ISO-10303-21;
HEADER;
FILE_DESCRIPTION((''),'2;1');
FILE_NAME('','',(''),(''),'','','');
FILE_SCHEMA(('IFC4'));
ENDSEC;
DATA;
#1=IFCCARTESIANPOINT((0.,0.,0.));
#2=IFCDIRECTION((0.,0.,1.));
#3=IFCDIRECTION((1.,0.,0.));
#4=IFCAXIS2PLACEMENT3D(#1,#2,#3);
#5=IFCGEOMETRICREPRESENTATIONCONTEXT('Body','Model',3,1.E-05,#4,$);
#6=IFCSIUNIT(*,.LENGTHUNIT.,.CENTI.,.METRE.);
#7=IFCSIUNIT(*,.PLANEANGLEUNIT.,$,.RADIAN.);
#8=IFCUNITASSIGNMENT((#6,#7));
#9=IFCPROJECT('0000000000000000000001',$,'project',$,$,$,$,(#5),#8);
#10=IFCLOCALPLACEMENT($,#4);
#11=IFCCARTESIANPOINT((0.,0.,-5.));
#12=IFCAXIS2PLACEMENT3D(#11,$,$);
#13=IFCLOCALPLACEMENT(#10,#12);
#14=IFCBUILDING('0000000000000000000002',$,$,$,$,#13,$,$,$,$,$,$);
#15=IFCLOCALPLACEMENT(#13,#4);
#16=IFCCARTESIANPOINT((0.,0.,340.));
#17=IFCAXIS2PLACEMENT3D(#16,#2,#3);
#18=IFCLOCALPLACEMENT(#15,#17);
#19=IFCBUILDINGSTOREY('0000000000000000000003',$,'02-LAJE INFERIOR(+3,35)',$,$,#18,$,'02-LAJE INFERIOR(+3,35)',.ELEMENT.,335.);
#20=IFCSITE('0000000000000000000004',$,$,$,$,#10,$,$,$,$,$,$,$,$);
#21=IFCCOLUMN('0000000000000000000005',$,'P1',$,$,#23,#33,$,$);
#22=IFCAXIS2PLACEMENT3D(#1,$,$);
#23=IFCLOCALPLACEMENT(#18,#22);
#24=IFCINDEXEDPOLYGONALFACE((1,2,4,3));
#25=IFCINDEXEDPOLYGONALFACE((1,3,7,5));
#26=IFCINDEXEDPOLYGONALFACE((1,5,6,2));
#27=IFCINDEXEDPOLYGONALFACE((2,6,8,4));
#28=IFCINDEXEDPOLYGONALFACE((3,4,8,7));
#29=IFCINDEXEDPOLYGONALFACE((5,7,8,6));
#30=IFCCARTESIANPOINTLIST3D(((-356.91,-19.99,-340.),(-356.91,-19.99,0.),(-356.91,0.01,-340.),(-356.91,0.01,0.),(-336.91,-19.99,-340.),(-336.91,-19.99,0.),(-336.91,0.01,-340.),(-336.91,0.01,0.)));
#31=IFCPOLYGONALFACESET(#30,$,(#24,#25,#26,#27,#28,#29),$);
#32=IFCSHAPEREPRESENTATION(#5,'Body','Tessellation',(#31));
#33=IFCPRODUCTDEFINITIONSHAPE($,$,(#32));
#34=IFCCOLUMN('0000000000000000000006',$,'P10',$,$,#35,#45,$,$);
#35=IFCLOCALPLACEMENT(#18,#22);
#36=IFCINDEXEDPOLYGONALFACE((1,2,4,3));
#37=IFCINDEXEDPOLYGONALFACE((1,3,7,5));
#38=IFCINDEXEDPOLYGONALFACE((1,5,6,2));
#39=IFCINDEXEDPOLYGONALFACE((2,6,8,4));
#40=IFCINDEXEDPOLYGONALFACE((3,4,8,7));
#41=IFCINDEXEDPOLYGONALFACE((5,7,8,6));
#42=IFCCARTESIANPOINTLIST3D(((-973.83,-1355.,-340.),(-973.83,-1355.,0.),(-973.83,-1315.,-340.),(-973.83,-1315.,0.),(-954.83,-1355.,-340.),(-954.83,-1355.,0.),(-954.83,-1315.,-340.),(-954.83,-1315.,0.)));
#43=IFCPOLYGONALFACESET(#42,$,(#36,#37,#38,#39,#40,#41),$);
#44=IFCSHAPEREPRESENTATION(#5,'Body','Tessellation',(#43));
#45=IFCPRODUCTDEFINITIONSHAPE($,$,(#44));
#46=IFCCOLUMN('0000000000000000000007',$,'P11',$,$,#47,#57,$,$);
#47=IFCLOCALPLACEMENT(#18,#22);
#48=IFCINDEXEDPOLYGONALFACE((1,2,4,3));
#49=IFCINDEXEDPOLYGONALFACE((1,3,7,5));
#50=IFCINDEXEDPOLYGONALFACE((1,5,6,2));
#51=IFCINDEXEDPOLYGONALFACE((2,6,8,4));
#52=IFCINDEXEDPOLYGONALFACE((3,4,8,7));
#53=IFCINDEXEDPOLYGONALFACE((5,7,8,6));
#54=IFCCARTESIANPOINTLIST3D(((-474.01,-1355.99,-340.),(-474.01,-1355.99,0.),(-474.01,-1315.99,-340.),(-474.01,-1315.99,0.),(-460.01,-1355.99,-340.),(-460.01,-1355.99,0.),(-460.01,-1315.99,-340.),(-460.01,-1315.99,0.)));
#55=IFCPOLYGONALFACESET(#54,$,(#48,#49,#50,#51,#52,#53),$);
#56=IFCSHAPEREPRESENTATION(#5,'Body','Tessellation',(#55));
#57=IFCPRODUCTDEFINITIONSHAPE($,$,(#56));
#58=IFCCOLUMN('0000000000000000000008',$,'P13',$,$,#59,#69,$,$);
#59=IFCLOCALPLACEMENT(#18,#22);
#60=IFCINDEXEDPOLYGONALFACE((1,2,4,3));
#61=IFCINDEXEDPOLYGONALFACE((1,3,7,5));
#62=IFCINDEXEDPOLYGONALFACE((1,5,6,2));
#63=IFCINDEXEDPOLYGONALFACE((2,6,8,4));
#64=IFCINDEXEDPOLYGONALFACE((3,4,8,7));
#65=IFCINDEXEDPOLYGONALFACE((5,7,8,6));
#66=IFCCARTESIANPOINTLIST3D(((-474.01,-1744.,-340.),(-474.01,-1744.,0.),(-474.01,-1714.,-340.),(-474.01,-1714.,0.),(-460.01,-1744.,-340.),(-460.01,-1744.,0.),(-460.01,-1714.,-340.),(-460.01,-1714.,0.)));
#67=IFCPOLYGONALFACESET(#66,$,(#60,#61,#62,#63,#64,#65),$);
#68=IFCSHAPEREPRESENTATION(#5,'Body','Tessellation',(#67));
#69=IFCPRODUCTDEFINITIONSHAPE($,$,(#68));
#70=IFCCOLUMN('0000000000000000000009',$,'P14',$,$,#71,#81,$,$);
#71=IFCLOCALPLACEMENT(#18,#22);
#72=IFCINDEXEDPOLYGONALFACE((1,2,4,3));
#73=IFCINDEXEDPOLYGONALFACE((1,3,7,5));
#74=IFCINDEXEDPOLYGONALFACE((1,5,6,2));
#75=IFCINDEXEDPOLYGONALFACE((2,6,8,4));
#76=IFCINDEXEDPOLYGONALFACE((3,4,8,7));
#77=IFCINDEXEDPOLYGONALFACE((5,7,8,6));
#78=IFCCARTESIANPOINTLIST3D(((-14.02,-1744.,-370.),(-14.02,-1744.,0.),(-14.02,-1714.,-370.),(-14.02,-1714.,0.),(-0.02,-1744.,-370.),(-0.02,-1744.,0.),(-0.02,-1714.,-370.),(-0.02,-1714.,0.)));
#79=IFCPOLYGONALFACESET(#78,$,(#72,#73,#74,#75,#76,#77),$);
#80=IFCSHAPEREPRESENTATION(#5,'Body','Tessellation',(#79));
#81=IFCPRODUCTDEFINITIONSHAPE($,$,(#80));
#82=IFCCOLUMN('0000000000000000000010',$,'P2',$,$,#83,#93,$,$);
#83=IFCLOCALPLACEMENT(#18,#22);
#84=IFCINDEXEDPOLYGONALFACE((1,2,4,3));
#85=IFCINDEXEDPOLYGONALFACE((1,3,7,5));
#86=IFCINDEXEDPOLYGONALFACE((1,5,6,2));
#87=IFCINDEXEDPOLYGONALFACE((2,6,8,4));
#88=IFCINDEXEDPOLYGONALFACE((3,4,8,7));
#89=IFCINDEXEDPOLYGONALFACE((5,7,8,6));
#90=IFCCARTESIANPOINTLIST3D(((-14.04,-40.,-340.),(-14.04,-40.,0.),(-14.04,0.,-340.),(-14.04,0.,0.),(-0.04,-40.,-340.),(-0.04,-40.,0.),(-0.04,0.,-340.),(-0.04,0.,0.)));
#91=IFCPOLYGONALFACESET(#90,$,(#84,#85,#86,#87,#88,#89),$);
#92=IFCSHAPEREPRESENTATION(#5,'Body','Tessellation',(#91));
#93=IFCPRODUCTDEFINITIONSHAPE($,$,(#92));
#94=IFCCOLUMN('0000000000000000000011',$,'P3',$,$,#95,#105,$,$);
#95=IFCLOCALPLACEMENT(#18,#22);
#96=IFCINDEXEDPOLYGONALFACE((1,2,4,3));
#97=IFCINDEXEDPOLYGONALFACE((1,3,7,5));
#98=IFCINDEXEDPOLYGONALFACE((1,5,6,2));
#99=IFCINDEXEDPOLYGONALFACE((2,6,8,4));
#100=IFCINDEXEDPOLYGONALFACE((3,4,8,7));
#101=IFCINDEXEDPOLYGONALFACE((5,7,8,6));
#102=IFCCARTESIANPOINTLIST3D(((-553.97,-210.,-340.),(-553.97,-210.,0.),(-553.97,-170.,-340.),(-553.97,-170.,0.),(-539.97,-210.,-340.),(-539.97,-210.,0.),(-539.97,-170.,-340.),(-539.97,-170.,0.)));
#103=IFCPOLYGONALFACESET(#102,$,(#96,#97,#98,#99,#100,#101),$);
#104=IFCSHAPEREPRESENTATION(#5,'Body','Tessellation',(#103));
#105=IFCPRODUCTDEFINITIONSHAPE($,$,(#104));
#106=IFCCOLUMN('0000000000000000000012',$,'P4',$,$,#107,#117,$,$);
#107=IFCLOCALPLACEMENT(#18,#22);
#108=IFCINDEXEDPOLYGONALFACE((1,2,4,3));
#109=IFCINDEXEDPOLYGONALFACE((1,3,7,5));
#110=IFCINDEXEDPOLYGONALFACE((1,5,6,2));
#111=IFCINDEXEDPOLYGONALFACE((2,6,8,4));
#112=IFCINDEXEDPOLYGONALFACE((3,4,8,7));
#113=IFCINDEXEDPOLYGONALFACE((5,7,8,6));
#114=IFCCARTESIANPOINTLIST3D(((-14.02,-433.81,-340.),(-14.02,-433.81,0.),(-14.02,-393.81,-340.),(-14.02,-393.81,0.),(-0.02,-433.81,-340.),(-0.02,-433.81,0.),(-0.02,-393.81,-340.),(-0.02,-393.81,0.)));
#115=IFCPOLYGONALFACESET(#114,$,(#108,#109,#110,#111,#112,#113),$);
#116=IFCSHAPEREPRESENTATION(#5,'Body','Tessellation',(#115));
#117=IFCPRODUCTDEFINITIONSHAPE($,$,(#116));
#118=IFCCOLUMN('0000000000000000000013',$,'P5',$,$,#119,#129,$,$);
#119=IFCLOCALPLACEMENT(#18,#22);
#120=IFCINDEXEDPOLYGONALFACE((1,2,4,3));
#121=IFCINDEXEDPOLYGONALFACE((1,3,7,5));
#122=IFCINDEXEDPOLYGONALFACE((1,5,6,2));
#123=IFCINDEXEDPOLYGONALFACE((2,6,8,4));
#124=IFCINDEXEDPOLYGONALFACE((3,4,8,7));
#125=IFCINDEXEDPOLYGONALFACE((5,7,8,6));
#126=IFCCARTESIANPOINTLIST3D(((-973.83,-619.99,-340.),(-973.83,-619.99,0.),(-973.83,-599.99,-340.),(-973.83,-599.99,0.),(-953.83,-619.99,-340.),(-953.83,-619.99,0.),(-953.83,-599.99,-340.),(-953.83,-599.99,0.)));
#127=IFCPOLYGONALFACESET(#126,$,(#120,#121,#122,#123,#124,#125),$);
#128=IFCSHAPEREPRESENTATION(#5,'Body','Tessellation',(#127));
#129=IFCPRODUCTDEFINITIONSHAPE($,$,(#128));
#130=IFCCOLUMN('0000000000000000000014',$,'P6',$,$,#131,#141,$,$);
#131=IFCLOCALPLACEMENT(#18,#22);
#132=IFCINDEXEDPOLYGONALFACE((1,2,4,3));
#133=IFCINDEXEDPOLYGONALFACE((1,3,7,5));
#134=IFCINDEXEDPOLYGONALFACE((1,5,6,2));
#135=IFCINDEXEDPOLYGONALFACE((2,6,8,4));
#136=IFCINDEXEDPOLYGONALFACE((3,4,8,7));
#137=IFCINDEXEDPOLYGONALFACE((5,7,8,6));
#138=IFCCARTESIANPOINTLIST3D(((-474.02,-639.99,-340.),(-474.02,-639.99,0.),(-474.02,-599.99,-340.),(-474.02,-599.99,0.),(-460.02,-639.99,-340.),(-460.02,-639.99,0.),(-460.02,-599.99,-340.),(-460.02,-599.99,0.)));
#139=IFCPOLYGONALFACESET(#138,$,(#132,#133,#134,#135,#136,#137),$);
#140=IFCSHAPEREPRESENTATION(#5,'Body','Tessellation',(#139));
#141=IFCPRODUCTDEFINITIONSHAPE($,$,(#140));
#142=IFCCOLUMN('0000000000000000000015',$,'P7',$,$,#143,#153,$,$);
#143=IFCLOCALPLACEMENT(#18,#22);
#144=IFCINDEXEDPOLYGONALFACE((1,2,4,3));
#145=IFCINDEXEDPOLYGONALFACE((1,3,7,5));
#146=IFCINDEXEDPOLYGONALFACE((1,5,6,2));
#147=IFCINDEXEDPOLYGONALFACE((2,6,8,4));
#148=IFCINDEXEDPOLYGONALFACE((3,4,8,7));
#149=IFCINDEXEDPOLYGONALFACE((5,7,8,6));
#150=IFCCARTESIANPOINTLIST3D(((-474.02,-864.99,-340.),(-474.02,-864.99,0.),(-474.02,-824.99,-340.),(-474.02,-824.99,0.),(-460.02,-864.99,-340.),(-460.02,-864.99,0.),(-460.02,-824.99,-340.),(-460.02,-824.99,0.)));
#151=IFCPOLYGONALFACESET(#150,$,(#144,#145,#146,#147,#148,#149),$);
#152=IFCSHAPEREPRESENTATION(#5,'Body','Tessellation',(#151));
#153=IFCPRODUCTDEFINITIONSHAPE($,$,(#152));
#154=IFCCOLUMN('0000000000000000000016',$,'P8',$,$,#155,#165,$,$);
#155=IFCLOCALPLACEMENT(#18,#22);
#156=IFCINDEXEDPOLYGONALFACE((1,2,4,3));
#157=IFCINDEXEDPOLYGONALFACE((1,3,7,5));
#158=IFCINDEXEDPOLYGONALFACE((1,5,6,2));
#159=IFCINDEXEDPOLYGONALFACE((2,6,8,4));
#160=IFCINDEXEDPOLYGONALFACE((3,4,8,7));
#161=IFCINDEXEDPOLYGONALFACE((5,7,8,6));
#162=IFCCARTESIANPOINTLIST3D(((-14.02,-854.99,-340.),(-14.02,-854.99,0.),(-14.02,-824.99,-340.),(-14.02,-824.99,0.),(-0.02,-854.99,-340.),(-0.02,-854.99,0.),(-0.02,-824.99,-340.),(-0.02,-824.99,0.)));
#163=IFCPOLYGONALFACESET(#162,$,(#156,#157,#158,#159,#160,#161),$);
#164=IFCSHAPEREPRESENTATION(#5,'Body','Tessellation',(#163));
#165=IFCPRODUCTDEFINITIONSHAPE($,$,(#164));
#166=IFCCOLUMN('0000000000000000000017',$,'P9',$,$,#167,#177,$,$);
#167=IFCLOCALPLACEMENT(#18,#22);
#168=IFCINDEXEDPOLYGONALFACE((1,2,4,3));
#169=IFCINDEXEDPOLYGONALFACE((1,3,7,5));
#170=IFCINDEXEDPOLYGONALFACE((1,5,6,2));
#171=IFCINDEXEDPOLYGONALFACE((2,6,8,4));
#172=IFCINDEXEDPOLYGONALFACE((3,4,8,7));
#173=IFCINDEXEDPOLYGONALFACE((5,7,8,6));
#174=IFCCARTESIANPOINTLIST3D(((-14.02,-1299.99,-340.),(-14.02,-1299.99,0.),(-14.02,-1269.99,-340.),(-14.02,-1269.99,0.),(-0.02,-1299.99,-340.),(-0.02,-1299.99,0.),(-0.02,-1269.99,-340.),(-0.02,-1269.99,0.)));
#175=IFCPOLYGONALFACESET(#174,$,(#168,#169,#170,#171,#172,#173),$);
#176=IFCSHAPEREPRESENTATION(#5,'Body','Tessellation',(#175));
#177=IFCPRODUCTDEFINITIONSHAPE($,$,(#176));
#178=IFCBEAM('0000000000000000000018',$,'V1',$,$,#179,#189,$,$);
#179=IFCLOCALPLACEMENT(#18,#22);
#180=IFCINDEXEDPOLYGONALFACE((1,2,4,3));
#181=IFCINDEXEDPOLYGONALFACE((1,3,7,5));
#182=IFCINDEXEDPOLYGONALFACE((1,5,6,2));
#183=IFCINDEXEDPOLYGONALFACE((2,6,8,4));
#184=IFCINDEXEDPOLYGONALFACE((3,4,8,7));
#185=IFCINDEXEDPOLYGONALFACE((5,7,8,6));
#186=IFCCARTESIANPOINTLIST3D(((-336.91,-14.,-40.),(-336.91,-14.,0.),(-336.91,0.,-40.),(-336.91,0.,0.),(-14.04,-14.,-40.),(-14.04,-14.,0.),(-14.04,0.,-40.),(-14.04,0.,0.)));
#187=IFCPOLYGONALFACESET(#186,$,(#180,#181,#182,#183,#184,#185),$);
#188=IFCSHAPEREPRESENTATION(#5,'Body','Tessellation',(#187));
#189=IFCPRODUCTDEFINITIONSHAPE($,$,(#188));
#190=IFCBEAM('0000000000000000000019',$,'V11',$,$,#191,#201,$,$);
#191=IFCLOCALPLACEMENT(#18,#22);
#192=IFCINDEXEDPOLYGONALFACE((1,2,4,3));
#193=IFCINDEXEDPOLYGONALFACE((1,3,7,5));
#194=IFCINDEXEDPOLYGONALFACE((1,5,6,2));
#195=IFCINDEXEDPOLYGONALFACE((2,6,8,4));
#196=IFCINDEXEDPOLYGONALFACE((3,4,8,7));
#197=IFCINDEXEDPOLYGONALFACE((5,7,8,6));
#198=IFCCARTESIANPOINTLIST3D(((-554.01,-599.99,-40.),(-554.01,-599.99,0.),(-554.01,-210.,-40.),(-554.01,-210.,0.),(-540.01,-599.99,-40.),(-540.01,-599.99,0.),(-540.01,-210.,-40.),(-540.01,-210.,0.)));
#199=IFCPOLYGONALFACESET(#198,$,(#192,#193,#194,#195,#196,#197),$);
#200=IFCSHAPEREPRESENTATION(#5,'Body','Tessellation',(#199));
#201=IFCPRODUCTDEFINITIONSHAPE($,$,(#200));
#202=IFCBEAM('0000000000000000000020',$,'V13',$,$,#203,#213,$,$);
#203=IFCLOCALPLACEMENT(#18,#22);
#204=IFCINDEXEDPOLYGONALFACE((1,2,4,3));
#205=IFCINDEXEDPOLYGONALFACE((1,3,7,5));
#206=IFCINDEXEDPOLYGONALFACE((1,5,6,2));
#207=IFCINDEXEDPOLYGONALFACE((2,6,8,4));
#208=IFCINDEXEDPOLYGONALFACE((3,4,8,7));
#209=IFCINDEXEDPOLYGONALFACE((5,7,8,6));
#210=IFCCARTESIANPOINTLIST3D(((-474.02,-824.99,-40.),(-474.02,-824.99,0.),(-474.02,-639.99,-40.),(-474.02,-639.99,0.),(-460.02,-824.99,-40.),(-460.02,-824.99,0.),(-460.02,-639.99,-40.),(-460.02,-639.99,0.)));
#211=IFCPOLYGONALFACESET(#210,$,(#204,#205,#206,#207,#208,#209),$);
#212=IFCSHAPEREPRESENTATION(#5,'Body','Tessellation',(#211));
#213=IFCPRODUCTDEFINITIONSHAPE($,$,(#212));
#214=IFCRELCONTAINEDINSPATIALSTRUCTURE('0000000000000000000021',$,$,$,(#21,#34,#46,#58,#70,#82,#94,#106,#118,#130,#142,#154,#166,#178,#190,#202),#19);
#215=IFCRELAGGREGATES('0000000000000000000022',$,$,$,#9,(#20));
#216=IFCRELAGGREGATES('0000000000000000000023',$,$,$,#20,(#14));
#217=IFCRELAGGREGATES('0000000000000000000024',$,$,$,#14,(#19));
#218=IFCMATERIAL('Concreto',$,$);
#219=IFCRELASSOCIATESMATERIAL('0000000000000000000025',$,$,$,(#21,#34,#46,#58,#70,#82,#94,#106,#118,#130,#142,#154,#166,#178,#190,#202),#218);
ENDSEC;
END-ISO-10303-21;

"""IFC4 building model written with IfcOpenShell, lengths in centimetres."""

from ifc_helpers import new_model, si_unit, frame, origin_with_axes, origin_2d_with_axis, place, context, project, spatial, rectangle, extrude, material, element, save


model = new_model("IFC4")

# Units and contexts
model_context = context("Model", 3, precision=1e-05, world=origin_with_axes(), identifier="Body")
ifc_project = project(units=[si_unit("LENGTHUNIT", "METRE", prefix="CENTI"), si_unit("PLANEANGLEUNIT", "RADIAN")], contexts=[model_context])

# Site, building, storey
site_placement = place(None, origin_with_axes())
site = spatial("IfcSite", under=ifc_project, at=site_placement)
building_placement = place(site_placement, frame((0.0, 0.0, -5.0)))
building = spatial("IfcBuilding", under=site, at=building_placement)
placement = place(building_placement, origin_with_axes())
storey_placement = place(placement, frame((0.0, 0.0, 340.0), z_axis=(0.0, 0.0, 1.0), x_axis=(1.0, 0.0, 0.0)))
storey = spatial("IfcBuildingStorey", under=building, at=storey_placement, Name="02-LAJE INFERIOR(+3,35)", LongName="02-LAJE INFERIOR(+3,35)", CompositionType="ELEMENT", Elevation=335.0)

# Columns
ifc_material = material(Name="Concreto")
column_1_placement = place(storey_placement, frame((-346.91, -9.99, 0.0), z_axis=(0.0, 0.0, 1.0), x_axis=(1.0, 0.0, 0.0)))
element("IfcColumn", 1, at=column_1_placement, inside=storey, material=ifc_material, Name="P1", context=model_context, shape_type="SolidModel", body=[
    extrude(rectangle(XDim=20.0, YDim=20.0, at=origin_2d_with_axis()), frame((0.0, 0.0, 0.0), z_axis=(0.0, 0.0, 1.0), x_axis=(-1.0, 0.0, 0.0)), (0.0, 0.0, -1.0), 340.0),
])
column_2_placement = place(storey_placement, frame((-964.33, -1335.0, 0.0), z_axis=(0.0, 0.0, 1.0), x_axis=(1.0, 0.0, 0.0)))
element("IfcColumn", 2, at=column_2_placement, inside=storey, material=ifc_material, Name="P10", context=model_context, shape_type="SolidModel", body=[
    extrude(rectangle(XDim=19.0, YDim=40.0, at=origin_2d_with_axis()), origin_with_axes(), (0.0, 0.0, -1.0), 340.0),
])
column_3_placement = place(storey_placement, frame((-467.01, -1335.99, 0.0), z_axis=(0.0, 0.0, 1.0), x_axis=(1.0, 0.0, 0.0)))
element("IfcColumn", 3, at=column_3_placement, inside=storey, material=ifc_material, Name="P11", context=model_context, shape_type="SolidModel", body=[
    extrude(rectangle(XDim=14.0, YDim=40.0, at=origin_2d_with_axis()), origin_with_axes(), (0.0, 0.0, -1.0), 340.0),
])
column_4_placement = place(storey_placement, frame((-467.01, -1729.0, 0.0), z_axis=(0.0, 0.0, 1.0), x_axis=(1.0, 0.0, 0.0)))
element("IfcColumn", 4, at=column_4_placement, inside=storey, material=ifc_material, Name="P13", context=model_context, shape_type="SolidModel", body=[
    extrude(rectangle(XDim=14.0, YDim=30.0, at=origin_2d_with_axis()), origin_with_axes(), (0.0, 0.0, -1.0), 340.0),
])
column_5_placement = place(storey_placement, frame((-7.02, -1729.0, 0.0), z_axis=(0.0, 0.0, 1.0), x_axis=(1.0, 0.0, 0.0)))
element("IfcColumn", 5, at=column_5_placement, inside=storey, material=ifc_material, Name="P14", context=model_context, shape_type="SolidModel", body=[
    extrude(rectangle(XDim=14.0, YDim=30.0, at=origin_2d_with_axis()), origin_with_axes(), (0.0, 0.0, -1.0), 370.0),
])
for number, where, z_axis, x_axis, name in (
    (6, (-7.04, -20.0, 0.0), (0.0, 0.0, 1.0), (1.0, 0.0, 0.0), "P2"),
    (7, (-546.97, -190.0, 0.0), (0.0, 0.0, 1.0), (1.0, 0.0, 0.0), "P3"),
    (8, (-7.02, -413.81, 0.0), (0.0, 0.0, 1.0), (1.0, 0.0, 0.0), "P4"),
):
    element("IfcColumn", number, at=place(storey_placement, frame(where, z_axis=z_axis, x_axis=x_axis)), inside=storey, material=ifc_material, Name=name, context=model_context, shape_type="SolidModel", body=[
        extrude(rectangle(XDim=14.0, YDim=40.0, at=origin_2d_with_axis()), origin_with_axes(), (0.0, 0.0, -1.0), 340.0),
    ])
column_6_placement = place(storey_placement, frame((-963.83, -609.99, 0.0), z_axis=(0.0, 0.0, 1.0), x_axis=(1.0, 0.0, 0.0)))
element("IfcColumn", 9, at=column_6_placement, inside=storey, material=ifc_material, Name="P5", context=model_context, shape_type="SolidModel", body=[
    extrude(rectangle(XDim=20.0, YDim=20.0, at=origin_2d_with_axis()), origin_with_axes(), (0.0, 0.0, -1.0), 340.0),
])
for number, where, z_axis, x_axis, name in (
    (10, (-467.02, -619.99, 0.0), (0.0, 0.0, 1.0), (1.0, 0.0, 0.0), "P6"),
    (11, (-467.02, -844.99, 0.0), (0.0, 0.0, 1.0), (1.0, 0.0, 0.0), "P7"),
):
    element("IfcColumn", number, at=place(storey_placement, frame(where, z_axis=z_axis, x_axis=x_axis)), inside=storey, material=ifc_material, Name=name, context=model_context, shape_type="SolidModel", body=[
        extrude(rectangle(XDim=14.0, YDim=40.0, at=origin_2d_with_axis()), origin_with_axes(), (0.0, 0.0, -1.0), 340.0),
    ])
for number, where, z_axis, x_axis, name in (
    (12, (-7.02, -839.99, 0.0), (0.0, 0.0, 1.0), (1.0, 0.0, 0.0), "P8"),
    (13, (-7.02, -1284.99, 0.0), (0.0, 0.0, 1.0), (1.0, 0.0, 0.0), "P9"),
):
    element("IfcColumn", number, at=place(storey_placement, frame(where, z_axis=z_axis, x_axis=x_axis)), inside=storey, material=ifc_material, Name=name, context=model_context, shape_type="SolidModel", body=[
        extrude(rectangle(XDim=14.0, YDim=30.0, at=origin_2d_with_axis()), origin_with_axes(), (0.0, 0.0, -1.0), 340.0),
    ])

# Beams
beam_1_placement = place(storey_placement, frame((-175.47, -7.0, 0.0), z_axis=(0.0, 0.0, 1.0), x_axis=(1.0, 0.0, 0.0)))
element("IfcBeam", 14, at=beam_1_placement, inside=storey, material=ifc_material, Name="V1", context=model_context, shape_type="SolidModel", body=[
    extrude(rectangle(XDim=14.0, YDim=40.0, at=origin_2d_with_axis()), frame((-161.44, 0.0, -20.0), z_axis=(1.0, 0.0, 0.0), x_axis=(0.0, -1.0, 0.0)), (0.0, 0.0, 1.0), 322.87),
])
beam_2_placement = place(storey_placement, frame((-547.01, -405.0, 0.0), z_axis=(0.0, 0.0, 1.0), x_axis=(1.0, 0.0, 0.0)))
element("IfcBeam", 15, at=beam_2_placement, inside=storey, material=ifc_material, Name="V11", context=model_context, shape_type="SolidModel", body=[
    extrude(rectangle(XDim=14.0, YDim=40.0, at=origin_2d_with_axis()), frame((0.0, -195.0, -20.0), z_axis=(0.0, 1.0, 0.0), x_axis=(-1.0, 0.0, 0.0)), (0.0, 0.0, 1.0), 389.99),
])
beam_3_placement = place(storey_placement, frame((-467.02, -732.49, 0.0), z_axis=(0.0, 0.0, 1.0), x_axis=(1.0, 0.0, 0.0)))
element("IfcBeam", 16, at=beam_3_placement, inside=storey, material=ifc_material, Name="V13", context=model_context, shape_type="SolidModel", body=[
    extrude(rectangle(XDim=14.0, YDim=40.0, at=origin_2d_with_axis()), frame((0.0, -92.5, -20.0), z_axis=(0.0, 1.0, 0.0), x_axis=(1.0, 0.0, 0.0)), (0.0, 0.0, 1.0), 185.0),
])

save(model, "model.ifc")
